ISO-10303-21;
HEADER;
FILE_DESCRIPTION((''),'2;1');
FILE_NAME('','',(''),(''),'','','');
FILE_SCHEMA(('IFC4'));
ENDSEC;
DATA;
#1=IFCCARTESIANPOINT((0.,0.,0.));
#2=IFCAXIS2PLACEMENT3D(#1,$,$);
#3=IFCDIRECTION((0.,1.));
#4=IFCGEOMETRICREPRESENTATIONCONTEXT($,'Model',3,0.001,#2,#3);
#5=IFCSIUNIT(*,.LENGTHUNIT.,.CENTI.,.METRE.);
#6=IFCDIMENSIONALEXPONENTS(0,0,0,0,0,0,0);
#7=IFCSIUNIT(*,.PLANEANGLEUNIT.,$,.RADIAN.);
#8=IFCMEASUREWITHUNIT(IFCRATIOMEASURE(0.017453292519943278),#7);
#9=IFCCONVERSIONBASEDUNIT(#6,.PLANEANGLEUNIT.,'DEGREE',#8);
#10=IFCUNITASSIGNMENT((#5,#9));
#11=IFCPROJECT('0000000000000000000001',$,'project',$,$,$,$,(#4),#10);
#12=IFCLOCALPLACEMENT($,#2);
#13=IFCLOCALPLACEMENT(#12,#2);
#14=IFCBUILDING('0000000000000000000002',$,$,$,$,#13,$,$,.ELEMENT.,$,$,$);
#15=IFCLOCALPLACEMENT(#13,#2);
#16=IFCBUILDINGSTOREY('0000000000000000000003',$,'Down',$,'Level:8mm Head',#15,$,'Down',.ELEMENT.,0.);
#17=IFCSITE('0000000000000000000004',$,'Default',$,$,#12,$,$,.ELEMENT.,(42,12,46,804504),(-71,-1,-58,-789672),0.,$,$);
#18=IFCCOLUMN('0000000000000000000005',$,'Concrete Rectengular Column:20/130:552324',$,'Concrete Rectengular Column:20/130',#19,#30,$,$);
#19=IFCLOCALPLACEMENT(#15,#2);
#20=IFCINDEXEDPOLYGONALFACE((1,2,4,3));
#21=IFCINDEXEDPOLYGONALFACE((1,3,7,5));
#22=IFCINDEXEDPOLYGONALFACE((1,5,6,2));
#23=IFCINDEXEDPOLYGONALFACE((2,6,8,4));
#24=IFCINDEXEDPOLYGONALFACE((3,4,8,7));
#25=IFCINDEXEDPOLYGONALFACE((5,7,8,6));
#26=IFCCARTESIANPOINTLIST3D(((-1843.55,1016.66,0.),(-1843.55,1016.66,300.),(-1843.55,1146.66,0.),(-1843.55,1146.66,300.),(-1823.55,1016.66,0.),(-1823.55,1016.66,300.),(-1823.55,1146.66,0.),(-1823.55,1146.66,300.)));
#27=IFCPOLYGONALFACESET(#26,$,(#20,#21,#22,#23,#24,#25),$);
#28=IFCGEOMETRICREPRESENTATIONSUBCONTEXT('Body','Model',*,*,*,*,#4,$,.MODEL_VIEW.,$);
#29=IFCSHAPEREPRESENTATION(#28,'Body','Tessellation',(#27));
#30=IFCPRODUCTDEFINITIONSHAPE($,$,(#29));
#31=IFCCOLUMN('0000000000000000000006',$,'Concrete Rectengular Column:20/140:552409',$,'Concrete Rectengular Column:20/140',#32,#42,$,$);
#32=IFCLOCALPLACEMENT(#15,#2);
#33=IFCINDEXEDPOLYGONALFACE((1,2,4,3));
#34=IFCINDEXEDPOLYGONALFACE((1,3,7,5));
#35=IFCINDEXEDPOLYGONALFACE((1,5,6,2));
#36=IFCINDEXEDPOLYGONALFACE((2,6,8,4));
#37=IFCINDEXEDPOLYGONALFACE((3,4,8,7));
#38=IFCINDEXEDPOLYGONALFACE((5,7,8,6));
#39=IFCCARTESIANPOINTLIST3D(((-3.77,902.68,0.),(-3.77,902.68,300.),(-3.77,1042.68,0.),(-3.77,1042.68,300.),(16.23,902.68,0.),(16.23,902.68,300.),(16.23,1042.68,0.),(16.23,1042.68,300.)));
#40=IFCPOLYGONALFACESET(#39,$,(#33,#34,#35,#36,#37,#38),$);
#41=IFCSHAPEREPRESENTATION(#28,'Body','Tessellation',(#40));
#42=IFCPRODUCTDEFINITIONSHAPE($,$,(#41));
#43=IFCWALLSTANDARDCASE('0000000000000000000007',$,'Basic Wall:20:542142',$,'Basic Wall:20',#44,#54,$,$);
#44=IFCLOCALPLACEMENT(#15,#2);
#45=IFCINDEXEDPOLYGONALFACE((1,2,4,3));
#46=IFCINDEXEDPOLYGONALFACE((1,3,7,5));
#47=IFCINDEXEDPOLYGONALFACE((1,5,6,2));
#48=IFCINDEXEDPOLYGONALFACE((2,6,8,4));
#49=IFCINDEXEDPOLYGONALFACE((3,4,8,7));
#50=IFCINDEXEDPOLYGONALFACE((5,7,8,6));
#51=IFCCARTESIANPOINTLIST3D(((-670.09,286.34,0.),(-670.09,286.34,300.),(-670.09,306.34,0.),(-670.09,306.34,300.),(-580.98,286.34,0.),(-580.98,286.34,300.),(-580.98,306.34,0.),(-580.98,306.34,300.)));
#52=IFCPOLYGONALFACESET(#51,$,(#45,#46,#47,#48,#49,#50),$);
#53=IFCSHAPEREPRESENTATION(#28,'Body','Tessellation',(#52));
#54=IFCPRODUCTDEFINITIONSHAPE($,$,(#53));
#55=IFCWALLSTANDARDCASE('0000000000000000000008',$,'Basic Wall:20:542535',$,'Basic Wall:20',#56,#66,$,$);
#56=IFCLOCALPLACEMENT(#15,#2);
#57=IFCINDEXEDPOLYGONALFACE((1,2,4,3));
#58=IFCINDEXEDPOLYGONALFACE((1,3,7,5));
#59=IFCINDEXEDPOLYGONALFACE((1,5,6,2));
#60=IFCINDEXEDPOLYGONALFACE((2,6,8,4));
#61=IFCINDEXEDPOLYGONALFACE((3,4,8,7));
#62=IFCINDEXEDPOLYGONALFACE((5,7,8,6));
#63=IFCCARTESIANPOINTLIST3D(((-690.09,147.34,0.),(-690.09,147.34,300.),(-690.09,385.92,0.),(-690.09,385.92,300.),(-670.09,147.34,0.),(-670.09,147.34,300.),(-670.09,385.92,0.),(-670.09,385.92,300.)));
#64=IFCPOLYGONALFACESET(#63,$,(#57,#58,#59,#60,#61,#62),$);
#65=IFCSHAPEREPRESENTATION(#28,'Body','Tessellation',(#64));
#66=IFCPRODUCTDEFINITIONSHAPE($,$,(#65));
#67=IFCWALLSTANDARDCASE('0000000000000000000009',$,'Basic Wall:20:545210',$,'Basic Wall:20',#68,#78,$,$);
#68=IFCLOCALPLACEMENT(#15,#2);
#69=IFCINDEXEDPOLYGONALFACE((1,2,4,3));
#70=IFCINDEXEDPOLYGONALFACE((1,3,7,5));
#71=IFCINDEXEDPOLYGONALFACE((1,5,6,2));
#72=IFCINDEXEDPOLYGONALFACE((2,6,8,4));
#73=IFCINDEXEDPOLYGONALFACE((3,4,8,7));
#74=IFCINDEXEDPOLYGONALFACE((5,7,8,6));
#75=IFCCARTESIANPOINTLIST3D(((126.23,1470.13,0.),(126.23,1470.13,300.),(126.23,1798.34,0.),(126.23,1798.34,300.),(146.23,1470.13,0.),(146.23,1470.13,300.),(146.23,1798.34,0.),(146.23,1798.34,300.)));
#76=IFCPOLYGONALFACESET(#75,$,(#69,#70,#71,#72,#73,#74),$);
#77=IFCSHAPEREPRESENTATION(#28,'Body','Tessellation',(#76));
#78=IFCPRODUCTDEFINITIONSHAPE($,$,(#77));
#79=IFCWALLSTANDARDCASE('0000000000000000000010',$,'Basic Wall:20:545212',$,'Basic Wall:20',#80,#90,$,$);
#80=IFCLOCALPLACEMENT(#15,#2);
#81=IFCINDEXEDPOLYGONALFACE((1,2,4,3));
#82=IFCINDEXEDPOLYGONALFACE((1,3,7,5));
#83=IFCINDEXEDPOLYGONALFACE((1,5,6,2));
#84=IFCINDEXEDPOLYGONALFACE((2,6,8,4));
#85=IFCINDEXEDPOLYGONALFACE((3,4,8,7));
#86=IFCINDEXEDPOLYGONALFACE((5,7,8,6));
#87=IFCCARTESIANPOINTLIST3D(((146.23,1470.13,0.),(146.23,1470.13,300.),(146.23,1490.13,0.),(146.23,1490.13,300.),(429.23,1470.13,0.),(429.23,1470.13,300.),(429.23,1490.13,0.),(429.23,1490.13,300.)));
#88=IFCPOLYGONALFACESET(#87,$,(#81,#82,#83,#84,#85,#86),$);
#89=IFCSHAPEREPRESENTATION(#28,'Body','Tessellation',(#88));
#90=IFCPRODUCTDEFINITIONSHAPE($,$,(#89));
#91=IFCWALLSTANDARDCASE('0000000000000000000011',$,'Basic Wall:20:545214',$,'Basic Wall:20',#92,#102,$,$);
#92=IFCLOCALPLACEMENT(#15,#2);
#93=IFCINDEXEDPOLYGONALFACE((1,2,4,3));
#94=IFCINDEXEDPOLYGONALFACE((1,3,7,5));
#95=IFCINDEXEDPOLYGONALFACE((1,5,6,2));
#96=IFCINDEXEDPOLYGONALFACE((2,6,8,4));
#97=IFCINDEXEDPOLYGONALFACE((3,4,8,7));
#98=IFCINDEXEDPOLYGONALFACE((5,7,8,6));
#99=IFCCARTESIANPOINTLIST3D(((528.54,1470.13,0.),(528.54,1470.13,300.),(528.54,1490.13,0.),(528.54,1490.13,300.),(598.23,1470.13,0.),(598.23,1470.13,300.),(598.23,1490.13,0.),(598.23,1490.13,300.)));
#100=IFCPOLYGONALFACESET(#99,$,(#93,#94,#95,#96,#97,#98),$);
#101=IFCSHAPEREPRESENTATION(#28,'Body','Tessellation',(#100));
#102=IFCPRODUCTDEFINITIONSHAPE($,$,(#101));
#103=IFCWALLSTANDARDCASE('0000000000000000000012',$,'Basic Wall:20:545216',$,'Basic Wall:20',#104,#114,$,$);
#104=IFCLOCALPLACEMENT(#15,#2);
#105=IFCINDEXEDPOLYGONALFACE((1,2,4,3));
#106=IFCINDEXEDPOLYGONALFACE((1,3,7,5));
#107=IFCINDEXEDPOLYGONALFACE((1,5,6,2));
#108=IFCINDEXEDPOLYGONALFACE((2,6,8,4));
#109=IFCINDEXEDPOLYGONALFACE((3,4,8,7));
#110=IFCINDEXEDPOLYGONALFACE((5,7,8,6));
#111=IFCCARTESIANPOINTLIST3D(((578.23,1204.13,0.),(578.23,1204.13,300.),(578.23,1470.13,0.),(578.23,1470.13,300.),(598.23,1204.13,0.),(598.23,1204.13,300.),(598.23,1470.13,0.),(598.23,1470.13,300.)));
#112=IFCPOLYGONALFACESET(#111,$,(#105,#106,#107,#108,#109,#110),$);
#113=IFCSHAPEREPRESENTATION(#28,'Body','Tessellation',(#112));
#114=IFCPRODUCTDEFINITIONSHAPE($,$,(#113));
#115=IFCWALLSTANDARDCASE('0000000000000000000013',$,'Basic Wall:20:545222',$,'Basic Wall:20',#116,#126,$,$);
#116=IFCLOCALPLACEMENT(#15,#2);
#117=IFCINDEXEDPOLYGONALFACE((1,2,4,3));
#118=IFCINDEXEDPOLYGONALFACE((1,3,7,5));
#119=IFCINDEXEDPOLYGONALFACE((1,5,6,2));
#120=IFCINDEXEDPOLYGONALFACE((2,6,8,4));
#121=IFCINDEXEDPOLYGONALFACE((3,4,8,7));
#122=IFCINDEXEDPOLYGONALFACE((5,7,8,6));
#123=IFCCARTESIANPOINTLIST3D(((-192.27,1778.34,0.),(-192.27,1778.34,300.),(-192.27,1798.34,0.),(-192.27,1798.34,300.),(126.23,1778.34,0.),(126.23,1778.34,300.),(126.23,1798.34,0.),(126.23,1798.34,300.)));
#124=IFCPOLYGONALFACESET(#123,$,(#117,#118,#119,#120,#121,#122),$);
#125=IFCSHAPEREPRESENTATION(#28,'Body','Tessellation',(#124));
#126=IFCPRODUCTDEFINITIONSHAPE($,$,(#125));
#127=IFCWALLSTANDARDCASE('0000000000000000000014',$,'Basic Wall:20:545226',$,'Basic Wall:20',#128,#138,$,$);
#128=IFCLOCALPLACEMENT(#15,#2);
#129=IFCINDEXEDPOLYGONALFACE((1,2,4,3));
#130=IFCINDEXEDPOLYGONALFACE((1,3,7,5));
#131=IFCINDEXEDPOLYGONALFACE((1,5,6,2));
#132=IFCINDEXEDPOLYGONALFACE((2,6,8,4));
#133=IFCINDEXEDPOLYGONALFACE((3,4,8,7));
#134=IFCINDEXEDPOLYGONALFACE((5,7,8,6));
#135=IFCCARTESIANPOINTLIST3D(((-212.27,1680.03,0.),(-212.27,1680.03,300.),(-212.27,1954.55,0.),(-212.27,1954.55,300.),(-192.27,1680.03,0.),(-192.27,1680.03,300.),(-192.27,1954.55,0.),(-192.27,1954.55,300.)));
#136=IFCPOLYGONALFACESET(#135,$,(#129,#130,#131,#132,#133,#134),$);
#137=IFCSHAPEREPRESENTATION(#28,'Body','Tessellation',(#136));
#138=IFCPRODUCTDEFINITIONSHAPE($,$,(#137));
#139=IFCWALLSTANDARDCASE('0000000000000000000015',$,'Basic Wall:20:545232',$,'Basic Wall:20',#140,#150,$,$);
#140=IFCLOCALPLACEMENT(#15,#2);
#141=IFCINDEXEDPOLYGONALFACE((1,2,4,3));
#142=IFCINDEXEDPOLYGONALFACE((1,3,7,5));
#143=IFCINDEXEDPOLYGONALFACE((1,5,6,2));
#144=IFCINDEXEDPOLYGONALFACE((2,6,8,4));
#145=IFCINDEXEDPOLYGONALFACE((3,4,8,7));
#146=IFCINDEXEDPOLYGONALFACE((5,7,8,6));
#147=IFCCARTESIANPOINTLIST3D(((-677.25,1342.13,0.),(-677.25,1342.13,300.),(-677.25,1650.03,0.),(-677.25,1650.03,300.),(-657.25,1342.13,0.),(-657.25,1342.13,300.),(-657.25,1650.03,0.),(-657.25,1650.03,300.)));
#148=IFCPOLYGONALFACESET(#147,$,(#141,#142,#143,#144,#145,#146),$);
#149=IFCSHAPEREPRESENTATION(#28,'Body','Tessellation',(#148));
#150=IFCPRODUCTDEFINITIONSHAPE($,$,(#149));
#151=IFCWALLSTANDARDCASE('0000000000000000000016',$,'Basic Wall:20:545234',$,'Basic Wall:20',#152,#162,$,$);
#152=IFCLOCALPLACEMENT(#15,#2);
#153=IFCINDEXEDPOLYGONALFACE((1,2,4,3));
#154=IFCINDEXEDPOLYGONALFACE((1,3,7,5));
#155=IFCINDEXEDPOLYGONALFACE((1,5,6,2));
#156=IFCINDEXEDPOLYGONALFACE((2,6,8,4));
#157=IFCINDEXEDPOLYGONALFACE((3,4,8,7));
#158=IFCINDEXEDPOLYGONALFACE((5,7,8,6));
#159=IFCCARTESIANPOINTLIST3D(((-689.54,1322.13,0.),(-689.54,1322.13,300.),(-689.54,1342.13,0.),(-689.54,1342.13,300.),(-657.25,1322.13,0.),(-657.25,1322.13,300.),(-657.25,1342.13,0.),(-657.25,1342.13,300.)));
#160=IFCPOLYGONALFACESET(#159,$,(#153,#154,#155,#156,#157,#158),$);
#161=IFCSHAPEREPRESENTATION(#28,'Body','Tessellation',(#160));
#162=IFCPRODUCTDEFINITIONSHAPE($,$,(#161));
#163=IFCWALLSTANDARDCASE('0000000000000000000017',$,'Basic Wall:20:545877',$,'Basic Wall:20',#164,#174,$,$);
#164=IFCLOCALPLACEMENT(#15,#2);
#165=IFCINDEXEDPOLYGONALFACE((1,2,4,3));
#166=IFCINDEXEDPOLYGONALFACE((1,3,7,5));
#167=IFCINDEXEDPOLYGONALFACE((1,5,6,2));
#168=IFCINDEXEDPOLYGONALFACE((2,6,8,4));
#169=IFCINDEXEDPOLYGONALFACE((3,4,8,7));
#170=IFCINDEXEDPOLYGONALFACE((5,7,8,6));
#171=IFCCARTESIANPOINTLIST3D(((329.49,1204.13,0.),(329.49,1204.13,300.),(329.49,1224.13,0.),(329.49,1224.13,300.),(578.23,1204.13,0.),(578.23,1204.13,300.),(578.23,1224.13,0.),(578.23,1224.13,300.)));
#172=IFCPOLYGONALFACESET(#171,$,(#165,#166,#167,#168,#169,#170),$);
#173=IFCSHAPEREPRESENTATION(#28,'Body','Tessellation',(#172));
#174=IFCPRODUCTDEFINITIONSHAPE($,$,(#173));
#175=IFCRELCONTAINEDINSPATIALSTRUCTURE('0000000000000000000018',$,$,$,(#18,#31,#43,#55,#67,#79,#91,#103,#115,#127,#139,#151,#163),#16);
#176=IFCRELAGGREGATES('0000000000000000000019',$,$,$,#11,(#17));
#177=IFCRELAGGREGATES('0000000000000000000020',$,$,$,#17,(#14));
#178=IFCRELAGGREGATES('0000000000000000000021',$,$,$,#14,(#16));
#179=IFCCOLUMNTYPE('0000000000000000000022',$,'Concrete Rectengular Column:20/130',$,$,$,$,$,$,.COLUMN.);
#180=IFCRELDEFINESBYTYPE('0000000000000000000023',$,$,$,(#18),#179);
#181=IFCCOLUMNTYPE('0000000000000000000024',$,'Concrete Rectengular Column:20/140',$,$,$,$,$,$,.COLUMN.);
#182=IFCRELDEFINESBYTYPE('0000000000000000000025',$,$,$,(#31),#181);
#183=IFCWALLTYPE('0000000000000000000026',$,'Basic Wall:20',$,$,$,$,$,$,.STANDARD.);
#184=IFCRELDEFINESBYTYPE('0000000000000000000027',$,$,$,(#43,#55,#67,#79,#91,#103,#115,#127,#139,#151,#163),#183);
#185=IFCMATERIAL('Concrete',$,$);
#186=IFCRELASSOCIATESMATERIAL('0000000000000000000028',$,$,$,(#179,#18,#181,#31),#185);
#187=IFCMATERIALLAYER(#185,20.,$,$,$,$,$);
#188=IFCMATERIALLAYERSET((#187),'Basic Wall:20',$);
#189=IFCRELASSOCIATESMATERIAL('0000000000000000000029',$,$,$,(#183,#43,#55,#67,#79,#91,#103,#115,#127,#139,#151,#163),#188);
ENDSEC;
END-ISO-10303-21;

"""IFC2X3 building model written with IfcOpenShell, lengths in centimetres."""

from ifc_helpers import new_model, entity, si_unit, converted_unit, direction, frame, frame_2d, origin, origin_2d_with_axis, place, context, subcontext, project, spatial, rectangle, extrude, source, transform, mapped, material, layer, layer_set, layer_usage, type_object, type_shapes, element, save


model = new_model("IFC2X3")

# Units and contexts
model_context = context("Model", 3, precision=0.001, world=origin(), true_north=direction((0.0, 1.0)))
body_context = subcontext(model_context, "Body", "Model", "MODEL_VIEW")
ifc_project = project(units=[si_unit("LENGTHUNIT", "METRE", prefix="CENTI"), converted_unit("PLANEANGLEUNIT", "DEGREE", entity("IfcRatioMeasure", 0.017453292519943278), si_unit("PLANEANGLEUNIT", "RADIAN"), dimensions=[0, 0, 0, 0, 0, 0, 0])], contexts=[model_context])

# Site, building, storey
site_placement = place(None, origin())
site = spatial("IfcSite", under=ifc_project, at=site_placement, Name="Default", CompositionType="ELEMENT", RefLatitude=(42, 12, 46, 804504), RefLongitude=(-71, -1, -58, -789672), RefElevation=0.0)
building_placement = place(site_placement, origin())
building = spatial("IfcBuilding", under=site, at=building_placement, CompositionType="ELEMENT")
storey_placement = place(building_placement, origin())
storey = spatial("IfcBuildingStorey", under=building, at=storey_placement, Name="Down", ObjectType="Level:8mm Head", LongName="Down", CompositionType="ELEMENT", Elevation=0.0)

# Columns
ifc_material = material(Name="Concrete")
column_type_1 = type_object("IfcColumnType", Name="Concrete Rectengular Column:20/130", PredefinedType="COLUMN", material=ifc_material)
shared_shape_1 = source(origin(), body_context, "Body", "SweptSolid", [
    extrude(rectangle(XDim=130.0, YDim=20.0, at=frame_2d((0.0, 0.0), x_axis=(1.0, 0.0))), frame((-1833.55, 1081.66, 0.0), z_axis=(0.0, 0.0, 1.0), x_axis=(0.0, -1.0, 0.0)), (0.0, 0.0, 1.0), 300.0),
])
type_shapes(column_type_1, [shared_shape_1])
column_1_placement = place(storey_placement, origin())
element("IfcColumn", 1, at=column_1_placement, inside=storey, type_object=column_type_1, material=ifc_material, Name="Concrete Rectengular Column:20/130:552324", ObjectType="Concrete Rectengular Column:20/130", context=body_context, shape_type="MappedRepresentation", body=[
    mapped(shared_shape_1, transform((0.0, 0.0, 0.0), scale=1.0)),
])
column_type_2 = type_object("IfcColumnType", Name="Concrete Rectengular Column:20/140", PredefinedType="COLUMN", material=ifc_material)
shared_shape_2 = source(origin(), body_context, "Body", "SweptSolid", [
    extrude(rectangle(XDim=140.0, YDim=20.0, at=origin_2d_with_axis()), frame((6.23, 972.68, 0.0), z_axis=(0.0, 0.0, 1.0), x_axis=(0.0, -1.0, 0.0)), (0.0, 0.0, 1.0), 300.0),
])
type_shapes(column_type_2, [shared_shape_2])
column_2_placement = place(storey_placement, origin())
element("IfcColumn", 2, at=column_2_placement, inside=storey, type_object=column_type_2, material=ifc_material, Name="Concrete Rectengular Column:20/140:552409", ObjectType="Concrete Rectengular Column:20/140", context=body_context, shape_type="MappedRepresentation", body=[
    mapped(shared_shape_2, transform((0.0, 0.0, 0.0), scale=1.0)),
])

# Walls
ifc_layer_1 = layer(ifc_material, 20.0)
ifc_layer_set_1 = layer_set([ifc_layer_1], Name="Basic Wall:20")
ifc_layer_usage_1 = layer_usage(ifc_layer_set_1, "AXIS2", "POSITIVE", -10.0)
wall_type_1 = type_object("IfcWallType", Name="Basic Wall:20", PredefinedType="STANDARD", material=ifc_layer_set_1)
wall_1_placement = place(storey_placement, frame((-580.98, 296.34, 0.0), z_axis=(0.0, 0.0, 1.0), x_axis=(-1.0, 0.0, 0.0)))
element("IfcWallStandardCase", 3, at=wall_1_placement, inside=storey, type_object=wall_type_1, material=ifc_layer_usage_1, Name="Basic Wall:20:542142", ObjectType="Basic Wall:20", context=body_context, shape_type="SweptSolid", body=[
    extrude(rectangle(XDim=89.11, YDim=20.0, at=frame_2d((44.55, 0.0), x_axis=(-1.0, 0.0))), origin(), (0.0, 0.0, 1.0), 300.0),
])
ifc_layer_usage_2 = layer_usage(ifc_layer_set_1, "AXIS2", "NEGATIVE", 10.0)
wall_2_placement = place(storey_placement, frame((-680.09, 147.34, 0.0), z_axis=(0.0, 0.0, 1.0), x_axis=(0.0, 1.0, 0.0)))
element("IfcWallStandardCase", 4, at=wall_2_placement, inside=storey, type_object=wall_type_1, material=ifc_layer_usage_2, Name="Basic Wall:20:542535", ObjectType="Basic Wall:20", context=body_context, shape_type="SweptSolid", body=[
    extrude(rectangle(XDim=238.58, YDim=20.0, at=frame_2d((119.29, 0.0), x_axis=(-1.0, 0.0))), origin(), (0.0, 0.0, 1.0), 300.0),
])
ifc_layer_usage_3 = layer_usage(ifc_layer_set_1, "AXIS2", "NEGATIVE", 10.0)
wall_3_placement = place(storey_placement, frame((136.23, 1798.34, 0.0), z_axis=(0.0, 0.0, 1.0), x_axis=(0.0, -1.0, 0.0)))
element("IfcWallStandardCase", 5, at=wall_3_placement, inside=storey, type_object=wall_type_1, material=ifc_layer_usage_3, Name="Basic Wall:20:545210", ObjectType="Basic Wall:20", context=body_context, shape_type="SweptSolid", body=[
    extrude(rectangle(XDim=328.21, YDim=20.0, at=frame_2d((164.11, 0.0), x_axis=(-1.0, 0.0))), origin(), (0.0, 0.0, 1.0), 300.0),
])
ifc_layer_usage_4 = layer_usage(ifc_layer_set_1, "AXIS2", "POSITIVE", -10.0)
wall_4_placement = place(storey_placement, frame((146.23, 1480.13, 0.0)))
element("IfcWallStandardCase", 6, at=wall_4_placement, inside=storey, type_object=wall_type_1, material=ifc_layer_usage_4, Name="Basic Wall:20:545212", ObjectType="Basic Wall:20", context=body_context, shape_type="SweptSolid", body=[
    extrude(rectangle(XDim=283.0, YDim=20.0, at=frame_2d((141.5, 0.0), x_axis=(-1.0, 0.0))), origin(), (0.0, 0.0, 1.0), 300.0),
])
ifc_layer_usage_5 = layer_usage(ifc_layer_set_1, "AXIS2", "POSITIVE", -10.0)
wall_5_placement = place(storey_placement, frame((528.54, 1480.13, 0.0)))
element("IfcWallStandardCase", 7, at=wall_5_placement, inside=storey, type_object=wall_type_1, material=ifc_layer_usage_5, Name="Basic Wall:20:545214", ObjectType="Basic Wall:20", context=body_context, shape_type="SweptSolid", body=[
    extrude(rectangle(XDim=69.68, YDim=20.0, at=frame_2d((34.84, 0.0), x_axis=(-1.0, 0.0))), origin(), (0.0, 0.0, 1.0), 300.0),
])
ifc_layer_usage_6 = layer_usage(ifc_layer_set_1, "AXIS2", "POSITIVE", -10.0)
wall_6_placement = place(storey_placement, frame((588.23, 1470.13, 0.0), z_axis=(0.0, 0.0, 1.0), x_axis=(0.0, -1.0, 0.0)))
element("IfcWallStandardCase", 8, at=wall_6_placement, inside=storey, type_object=wall_type_1, material=ifc_layer_usage_6, Name="Basic Wall:20:545216", ObjectType="Basic Wall:20", context=body_context, shape_type="SweptSolid", body=[
    extrude(rectangle(XDim=266.0, YDim=20.0, at=frame_2d((133.0, 0.0), x_axis=(-1.0, 0.0))), origin(), (0.0, 0.0, 1.0), 300.0),
])
ifc_layer_usage_7 = layer_usage(ifc_layer_set_1, "AXIS2", "NEGATIVE", 10.0)
wall_7_placement = place(storey_placement, frame((126.23, 1788.34, 0.0), z_axis=(0.0, 0.0, 1.0), x_axis=(-1.0, 0.0, 0.0)))
element("IfcWallStandardCase", 9, at=wall_7_placement, inside=storey, type_object=wall_type_1, material=ifc_layer_usage_7, Name="Basic Wall:20:545222", ObjectType="Basic Wall:20", context=body_context, shape_type="SweptSolid", body=[
    extrude(rectangle(XDim=318.5, YDim=20.0, at=frame_2d((159.25, 0.0), x_axis=(-1.0, 0.0))), origin(), (0.0, 0.0, 1.0), 300.0),
])
ifc_layer_usage_8 = layer_usage(ifc_layer_set_1, "AXIS2", "NEGATIVE", 10.0)
wall_8_placement = place(storey_placement, frame((-202.27, 1680.03, 0.0), z_axis=(0.0, 0.0, 1.0), x_axis=(0.0, 1.0, 0.0)))
element("IfcWallStandardCase", 10, at=wall_8_placement, inside=storey, type_object=wall_type_1, material=ifc_layer_usage_8, Name="Basic Wall:20:545226", ObjectType="Basic Wall:20", context=body_context, shape_type="SweptSolid", body=[
    extrude(rectangle(XDim=274.53, YDim=20.0, at=frame_2d((137.26, 0.0), x_axis=(-1.0, 0.0))), origin(), (0.0, 0.0, 1.0), 300.0),
])
ifc_layer_usage_9 = layer_usage(ifc_layer_set_1, "AXIS2", "POSITIVE", -10.0)
wall_9_placement = place(storey_placement, frame((-667.25, 1650.03, 0.0), z_axis=(0.0, 0.0, 1.0), x_axis=(0.0, -1.0, 0.0)))
element("IfcWallStandardCase", 11, at=wall_9_placement, inside=storey, type_object=wall_type_1, material=ifc_layer_usage_9, Name="Basic Wall:20:545232", ObjectType="Basic Wall:20", context=body_context, shape_type="SweptSolid", body=[
    extrude(rectangle(XDim=307.89, YDim=20.0, at=frame_2d((153.95, 0.0), x_axis=(-1.0, 0.0))), origin(), (0.0, 0.0, 1.0), 300.0),
])
ifc_layer_usage_10 = layer_usage(ifc_layer_set_1, "AXIS2", "NEGATIVE", 10.0)
wall_10_placement = place(storey_placement, frame((-657.25, 1332.13, 0.0), z_axis=(0.0, 0.0, 1.0), x_axis=(-1.0, 0.0, 0.0)))
element("IfcWallStandardCase", 12, at=wall_10_placement, inside=storey, type_object=wall_type_1, material=ifc_layer_usage_10, Name="Basic Wall:20:545234", ObjectType="Basic Wall:20", context=body_context, shape_type="SweptSolid", body=[
    extrude(rectangle(XDim=32.29, YDim=20.0, at=frame_2d((16.14, 0.0), x_axis=(-1.0, 0.0))), origin(), (0.0, 0.0, 1.0), 300.0),
])
ifc_layer_usage_11 = layer_usage(ifc_layer_set_1, "AXIS2", "NEGATIVE", 10.0)
wall_11_placement = place(storey_placement, frame((578.23, 1214.13, 0.0), z_axis=(0.0, 0.0, 1.0), x_axis=(-1.0, 0.0, 0.0)))
element("IfcWallStandardCase", 13, at=wall_11_placement, inside=storey, type_object=wall_type_1, material=ifc_layer_usage_11, Name="Basic Wall:20:545877", ObjectType="Basic Wall:20", context=body_context, shape_type="SweptSolid", body=[
    extrude(rectangle(XDim=248.74, YDim=20.0, at=frame_2d((124.37, 0.0), x_axis=(-1.0, 0.0))), origin(), (0.0, 0.0, 1.0), 300.0),
])

save(model, "model.ifc")
